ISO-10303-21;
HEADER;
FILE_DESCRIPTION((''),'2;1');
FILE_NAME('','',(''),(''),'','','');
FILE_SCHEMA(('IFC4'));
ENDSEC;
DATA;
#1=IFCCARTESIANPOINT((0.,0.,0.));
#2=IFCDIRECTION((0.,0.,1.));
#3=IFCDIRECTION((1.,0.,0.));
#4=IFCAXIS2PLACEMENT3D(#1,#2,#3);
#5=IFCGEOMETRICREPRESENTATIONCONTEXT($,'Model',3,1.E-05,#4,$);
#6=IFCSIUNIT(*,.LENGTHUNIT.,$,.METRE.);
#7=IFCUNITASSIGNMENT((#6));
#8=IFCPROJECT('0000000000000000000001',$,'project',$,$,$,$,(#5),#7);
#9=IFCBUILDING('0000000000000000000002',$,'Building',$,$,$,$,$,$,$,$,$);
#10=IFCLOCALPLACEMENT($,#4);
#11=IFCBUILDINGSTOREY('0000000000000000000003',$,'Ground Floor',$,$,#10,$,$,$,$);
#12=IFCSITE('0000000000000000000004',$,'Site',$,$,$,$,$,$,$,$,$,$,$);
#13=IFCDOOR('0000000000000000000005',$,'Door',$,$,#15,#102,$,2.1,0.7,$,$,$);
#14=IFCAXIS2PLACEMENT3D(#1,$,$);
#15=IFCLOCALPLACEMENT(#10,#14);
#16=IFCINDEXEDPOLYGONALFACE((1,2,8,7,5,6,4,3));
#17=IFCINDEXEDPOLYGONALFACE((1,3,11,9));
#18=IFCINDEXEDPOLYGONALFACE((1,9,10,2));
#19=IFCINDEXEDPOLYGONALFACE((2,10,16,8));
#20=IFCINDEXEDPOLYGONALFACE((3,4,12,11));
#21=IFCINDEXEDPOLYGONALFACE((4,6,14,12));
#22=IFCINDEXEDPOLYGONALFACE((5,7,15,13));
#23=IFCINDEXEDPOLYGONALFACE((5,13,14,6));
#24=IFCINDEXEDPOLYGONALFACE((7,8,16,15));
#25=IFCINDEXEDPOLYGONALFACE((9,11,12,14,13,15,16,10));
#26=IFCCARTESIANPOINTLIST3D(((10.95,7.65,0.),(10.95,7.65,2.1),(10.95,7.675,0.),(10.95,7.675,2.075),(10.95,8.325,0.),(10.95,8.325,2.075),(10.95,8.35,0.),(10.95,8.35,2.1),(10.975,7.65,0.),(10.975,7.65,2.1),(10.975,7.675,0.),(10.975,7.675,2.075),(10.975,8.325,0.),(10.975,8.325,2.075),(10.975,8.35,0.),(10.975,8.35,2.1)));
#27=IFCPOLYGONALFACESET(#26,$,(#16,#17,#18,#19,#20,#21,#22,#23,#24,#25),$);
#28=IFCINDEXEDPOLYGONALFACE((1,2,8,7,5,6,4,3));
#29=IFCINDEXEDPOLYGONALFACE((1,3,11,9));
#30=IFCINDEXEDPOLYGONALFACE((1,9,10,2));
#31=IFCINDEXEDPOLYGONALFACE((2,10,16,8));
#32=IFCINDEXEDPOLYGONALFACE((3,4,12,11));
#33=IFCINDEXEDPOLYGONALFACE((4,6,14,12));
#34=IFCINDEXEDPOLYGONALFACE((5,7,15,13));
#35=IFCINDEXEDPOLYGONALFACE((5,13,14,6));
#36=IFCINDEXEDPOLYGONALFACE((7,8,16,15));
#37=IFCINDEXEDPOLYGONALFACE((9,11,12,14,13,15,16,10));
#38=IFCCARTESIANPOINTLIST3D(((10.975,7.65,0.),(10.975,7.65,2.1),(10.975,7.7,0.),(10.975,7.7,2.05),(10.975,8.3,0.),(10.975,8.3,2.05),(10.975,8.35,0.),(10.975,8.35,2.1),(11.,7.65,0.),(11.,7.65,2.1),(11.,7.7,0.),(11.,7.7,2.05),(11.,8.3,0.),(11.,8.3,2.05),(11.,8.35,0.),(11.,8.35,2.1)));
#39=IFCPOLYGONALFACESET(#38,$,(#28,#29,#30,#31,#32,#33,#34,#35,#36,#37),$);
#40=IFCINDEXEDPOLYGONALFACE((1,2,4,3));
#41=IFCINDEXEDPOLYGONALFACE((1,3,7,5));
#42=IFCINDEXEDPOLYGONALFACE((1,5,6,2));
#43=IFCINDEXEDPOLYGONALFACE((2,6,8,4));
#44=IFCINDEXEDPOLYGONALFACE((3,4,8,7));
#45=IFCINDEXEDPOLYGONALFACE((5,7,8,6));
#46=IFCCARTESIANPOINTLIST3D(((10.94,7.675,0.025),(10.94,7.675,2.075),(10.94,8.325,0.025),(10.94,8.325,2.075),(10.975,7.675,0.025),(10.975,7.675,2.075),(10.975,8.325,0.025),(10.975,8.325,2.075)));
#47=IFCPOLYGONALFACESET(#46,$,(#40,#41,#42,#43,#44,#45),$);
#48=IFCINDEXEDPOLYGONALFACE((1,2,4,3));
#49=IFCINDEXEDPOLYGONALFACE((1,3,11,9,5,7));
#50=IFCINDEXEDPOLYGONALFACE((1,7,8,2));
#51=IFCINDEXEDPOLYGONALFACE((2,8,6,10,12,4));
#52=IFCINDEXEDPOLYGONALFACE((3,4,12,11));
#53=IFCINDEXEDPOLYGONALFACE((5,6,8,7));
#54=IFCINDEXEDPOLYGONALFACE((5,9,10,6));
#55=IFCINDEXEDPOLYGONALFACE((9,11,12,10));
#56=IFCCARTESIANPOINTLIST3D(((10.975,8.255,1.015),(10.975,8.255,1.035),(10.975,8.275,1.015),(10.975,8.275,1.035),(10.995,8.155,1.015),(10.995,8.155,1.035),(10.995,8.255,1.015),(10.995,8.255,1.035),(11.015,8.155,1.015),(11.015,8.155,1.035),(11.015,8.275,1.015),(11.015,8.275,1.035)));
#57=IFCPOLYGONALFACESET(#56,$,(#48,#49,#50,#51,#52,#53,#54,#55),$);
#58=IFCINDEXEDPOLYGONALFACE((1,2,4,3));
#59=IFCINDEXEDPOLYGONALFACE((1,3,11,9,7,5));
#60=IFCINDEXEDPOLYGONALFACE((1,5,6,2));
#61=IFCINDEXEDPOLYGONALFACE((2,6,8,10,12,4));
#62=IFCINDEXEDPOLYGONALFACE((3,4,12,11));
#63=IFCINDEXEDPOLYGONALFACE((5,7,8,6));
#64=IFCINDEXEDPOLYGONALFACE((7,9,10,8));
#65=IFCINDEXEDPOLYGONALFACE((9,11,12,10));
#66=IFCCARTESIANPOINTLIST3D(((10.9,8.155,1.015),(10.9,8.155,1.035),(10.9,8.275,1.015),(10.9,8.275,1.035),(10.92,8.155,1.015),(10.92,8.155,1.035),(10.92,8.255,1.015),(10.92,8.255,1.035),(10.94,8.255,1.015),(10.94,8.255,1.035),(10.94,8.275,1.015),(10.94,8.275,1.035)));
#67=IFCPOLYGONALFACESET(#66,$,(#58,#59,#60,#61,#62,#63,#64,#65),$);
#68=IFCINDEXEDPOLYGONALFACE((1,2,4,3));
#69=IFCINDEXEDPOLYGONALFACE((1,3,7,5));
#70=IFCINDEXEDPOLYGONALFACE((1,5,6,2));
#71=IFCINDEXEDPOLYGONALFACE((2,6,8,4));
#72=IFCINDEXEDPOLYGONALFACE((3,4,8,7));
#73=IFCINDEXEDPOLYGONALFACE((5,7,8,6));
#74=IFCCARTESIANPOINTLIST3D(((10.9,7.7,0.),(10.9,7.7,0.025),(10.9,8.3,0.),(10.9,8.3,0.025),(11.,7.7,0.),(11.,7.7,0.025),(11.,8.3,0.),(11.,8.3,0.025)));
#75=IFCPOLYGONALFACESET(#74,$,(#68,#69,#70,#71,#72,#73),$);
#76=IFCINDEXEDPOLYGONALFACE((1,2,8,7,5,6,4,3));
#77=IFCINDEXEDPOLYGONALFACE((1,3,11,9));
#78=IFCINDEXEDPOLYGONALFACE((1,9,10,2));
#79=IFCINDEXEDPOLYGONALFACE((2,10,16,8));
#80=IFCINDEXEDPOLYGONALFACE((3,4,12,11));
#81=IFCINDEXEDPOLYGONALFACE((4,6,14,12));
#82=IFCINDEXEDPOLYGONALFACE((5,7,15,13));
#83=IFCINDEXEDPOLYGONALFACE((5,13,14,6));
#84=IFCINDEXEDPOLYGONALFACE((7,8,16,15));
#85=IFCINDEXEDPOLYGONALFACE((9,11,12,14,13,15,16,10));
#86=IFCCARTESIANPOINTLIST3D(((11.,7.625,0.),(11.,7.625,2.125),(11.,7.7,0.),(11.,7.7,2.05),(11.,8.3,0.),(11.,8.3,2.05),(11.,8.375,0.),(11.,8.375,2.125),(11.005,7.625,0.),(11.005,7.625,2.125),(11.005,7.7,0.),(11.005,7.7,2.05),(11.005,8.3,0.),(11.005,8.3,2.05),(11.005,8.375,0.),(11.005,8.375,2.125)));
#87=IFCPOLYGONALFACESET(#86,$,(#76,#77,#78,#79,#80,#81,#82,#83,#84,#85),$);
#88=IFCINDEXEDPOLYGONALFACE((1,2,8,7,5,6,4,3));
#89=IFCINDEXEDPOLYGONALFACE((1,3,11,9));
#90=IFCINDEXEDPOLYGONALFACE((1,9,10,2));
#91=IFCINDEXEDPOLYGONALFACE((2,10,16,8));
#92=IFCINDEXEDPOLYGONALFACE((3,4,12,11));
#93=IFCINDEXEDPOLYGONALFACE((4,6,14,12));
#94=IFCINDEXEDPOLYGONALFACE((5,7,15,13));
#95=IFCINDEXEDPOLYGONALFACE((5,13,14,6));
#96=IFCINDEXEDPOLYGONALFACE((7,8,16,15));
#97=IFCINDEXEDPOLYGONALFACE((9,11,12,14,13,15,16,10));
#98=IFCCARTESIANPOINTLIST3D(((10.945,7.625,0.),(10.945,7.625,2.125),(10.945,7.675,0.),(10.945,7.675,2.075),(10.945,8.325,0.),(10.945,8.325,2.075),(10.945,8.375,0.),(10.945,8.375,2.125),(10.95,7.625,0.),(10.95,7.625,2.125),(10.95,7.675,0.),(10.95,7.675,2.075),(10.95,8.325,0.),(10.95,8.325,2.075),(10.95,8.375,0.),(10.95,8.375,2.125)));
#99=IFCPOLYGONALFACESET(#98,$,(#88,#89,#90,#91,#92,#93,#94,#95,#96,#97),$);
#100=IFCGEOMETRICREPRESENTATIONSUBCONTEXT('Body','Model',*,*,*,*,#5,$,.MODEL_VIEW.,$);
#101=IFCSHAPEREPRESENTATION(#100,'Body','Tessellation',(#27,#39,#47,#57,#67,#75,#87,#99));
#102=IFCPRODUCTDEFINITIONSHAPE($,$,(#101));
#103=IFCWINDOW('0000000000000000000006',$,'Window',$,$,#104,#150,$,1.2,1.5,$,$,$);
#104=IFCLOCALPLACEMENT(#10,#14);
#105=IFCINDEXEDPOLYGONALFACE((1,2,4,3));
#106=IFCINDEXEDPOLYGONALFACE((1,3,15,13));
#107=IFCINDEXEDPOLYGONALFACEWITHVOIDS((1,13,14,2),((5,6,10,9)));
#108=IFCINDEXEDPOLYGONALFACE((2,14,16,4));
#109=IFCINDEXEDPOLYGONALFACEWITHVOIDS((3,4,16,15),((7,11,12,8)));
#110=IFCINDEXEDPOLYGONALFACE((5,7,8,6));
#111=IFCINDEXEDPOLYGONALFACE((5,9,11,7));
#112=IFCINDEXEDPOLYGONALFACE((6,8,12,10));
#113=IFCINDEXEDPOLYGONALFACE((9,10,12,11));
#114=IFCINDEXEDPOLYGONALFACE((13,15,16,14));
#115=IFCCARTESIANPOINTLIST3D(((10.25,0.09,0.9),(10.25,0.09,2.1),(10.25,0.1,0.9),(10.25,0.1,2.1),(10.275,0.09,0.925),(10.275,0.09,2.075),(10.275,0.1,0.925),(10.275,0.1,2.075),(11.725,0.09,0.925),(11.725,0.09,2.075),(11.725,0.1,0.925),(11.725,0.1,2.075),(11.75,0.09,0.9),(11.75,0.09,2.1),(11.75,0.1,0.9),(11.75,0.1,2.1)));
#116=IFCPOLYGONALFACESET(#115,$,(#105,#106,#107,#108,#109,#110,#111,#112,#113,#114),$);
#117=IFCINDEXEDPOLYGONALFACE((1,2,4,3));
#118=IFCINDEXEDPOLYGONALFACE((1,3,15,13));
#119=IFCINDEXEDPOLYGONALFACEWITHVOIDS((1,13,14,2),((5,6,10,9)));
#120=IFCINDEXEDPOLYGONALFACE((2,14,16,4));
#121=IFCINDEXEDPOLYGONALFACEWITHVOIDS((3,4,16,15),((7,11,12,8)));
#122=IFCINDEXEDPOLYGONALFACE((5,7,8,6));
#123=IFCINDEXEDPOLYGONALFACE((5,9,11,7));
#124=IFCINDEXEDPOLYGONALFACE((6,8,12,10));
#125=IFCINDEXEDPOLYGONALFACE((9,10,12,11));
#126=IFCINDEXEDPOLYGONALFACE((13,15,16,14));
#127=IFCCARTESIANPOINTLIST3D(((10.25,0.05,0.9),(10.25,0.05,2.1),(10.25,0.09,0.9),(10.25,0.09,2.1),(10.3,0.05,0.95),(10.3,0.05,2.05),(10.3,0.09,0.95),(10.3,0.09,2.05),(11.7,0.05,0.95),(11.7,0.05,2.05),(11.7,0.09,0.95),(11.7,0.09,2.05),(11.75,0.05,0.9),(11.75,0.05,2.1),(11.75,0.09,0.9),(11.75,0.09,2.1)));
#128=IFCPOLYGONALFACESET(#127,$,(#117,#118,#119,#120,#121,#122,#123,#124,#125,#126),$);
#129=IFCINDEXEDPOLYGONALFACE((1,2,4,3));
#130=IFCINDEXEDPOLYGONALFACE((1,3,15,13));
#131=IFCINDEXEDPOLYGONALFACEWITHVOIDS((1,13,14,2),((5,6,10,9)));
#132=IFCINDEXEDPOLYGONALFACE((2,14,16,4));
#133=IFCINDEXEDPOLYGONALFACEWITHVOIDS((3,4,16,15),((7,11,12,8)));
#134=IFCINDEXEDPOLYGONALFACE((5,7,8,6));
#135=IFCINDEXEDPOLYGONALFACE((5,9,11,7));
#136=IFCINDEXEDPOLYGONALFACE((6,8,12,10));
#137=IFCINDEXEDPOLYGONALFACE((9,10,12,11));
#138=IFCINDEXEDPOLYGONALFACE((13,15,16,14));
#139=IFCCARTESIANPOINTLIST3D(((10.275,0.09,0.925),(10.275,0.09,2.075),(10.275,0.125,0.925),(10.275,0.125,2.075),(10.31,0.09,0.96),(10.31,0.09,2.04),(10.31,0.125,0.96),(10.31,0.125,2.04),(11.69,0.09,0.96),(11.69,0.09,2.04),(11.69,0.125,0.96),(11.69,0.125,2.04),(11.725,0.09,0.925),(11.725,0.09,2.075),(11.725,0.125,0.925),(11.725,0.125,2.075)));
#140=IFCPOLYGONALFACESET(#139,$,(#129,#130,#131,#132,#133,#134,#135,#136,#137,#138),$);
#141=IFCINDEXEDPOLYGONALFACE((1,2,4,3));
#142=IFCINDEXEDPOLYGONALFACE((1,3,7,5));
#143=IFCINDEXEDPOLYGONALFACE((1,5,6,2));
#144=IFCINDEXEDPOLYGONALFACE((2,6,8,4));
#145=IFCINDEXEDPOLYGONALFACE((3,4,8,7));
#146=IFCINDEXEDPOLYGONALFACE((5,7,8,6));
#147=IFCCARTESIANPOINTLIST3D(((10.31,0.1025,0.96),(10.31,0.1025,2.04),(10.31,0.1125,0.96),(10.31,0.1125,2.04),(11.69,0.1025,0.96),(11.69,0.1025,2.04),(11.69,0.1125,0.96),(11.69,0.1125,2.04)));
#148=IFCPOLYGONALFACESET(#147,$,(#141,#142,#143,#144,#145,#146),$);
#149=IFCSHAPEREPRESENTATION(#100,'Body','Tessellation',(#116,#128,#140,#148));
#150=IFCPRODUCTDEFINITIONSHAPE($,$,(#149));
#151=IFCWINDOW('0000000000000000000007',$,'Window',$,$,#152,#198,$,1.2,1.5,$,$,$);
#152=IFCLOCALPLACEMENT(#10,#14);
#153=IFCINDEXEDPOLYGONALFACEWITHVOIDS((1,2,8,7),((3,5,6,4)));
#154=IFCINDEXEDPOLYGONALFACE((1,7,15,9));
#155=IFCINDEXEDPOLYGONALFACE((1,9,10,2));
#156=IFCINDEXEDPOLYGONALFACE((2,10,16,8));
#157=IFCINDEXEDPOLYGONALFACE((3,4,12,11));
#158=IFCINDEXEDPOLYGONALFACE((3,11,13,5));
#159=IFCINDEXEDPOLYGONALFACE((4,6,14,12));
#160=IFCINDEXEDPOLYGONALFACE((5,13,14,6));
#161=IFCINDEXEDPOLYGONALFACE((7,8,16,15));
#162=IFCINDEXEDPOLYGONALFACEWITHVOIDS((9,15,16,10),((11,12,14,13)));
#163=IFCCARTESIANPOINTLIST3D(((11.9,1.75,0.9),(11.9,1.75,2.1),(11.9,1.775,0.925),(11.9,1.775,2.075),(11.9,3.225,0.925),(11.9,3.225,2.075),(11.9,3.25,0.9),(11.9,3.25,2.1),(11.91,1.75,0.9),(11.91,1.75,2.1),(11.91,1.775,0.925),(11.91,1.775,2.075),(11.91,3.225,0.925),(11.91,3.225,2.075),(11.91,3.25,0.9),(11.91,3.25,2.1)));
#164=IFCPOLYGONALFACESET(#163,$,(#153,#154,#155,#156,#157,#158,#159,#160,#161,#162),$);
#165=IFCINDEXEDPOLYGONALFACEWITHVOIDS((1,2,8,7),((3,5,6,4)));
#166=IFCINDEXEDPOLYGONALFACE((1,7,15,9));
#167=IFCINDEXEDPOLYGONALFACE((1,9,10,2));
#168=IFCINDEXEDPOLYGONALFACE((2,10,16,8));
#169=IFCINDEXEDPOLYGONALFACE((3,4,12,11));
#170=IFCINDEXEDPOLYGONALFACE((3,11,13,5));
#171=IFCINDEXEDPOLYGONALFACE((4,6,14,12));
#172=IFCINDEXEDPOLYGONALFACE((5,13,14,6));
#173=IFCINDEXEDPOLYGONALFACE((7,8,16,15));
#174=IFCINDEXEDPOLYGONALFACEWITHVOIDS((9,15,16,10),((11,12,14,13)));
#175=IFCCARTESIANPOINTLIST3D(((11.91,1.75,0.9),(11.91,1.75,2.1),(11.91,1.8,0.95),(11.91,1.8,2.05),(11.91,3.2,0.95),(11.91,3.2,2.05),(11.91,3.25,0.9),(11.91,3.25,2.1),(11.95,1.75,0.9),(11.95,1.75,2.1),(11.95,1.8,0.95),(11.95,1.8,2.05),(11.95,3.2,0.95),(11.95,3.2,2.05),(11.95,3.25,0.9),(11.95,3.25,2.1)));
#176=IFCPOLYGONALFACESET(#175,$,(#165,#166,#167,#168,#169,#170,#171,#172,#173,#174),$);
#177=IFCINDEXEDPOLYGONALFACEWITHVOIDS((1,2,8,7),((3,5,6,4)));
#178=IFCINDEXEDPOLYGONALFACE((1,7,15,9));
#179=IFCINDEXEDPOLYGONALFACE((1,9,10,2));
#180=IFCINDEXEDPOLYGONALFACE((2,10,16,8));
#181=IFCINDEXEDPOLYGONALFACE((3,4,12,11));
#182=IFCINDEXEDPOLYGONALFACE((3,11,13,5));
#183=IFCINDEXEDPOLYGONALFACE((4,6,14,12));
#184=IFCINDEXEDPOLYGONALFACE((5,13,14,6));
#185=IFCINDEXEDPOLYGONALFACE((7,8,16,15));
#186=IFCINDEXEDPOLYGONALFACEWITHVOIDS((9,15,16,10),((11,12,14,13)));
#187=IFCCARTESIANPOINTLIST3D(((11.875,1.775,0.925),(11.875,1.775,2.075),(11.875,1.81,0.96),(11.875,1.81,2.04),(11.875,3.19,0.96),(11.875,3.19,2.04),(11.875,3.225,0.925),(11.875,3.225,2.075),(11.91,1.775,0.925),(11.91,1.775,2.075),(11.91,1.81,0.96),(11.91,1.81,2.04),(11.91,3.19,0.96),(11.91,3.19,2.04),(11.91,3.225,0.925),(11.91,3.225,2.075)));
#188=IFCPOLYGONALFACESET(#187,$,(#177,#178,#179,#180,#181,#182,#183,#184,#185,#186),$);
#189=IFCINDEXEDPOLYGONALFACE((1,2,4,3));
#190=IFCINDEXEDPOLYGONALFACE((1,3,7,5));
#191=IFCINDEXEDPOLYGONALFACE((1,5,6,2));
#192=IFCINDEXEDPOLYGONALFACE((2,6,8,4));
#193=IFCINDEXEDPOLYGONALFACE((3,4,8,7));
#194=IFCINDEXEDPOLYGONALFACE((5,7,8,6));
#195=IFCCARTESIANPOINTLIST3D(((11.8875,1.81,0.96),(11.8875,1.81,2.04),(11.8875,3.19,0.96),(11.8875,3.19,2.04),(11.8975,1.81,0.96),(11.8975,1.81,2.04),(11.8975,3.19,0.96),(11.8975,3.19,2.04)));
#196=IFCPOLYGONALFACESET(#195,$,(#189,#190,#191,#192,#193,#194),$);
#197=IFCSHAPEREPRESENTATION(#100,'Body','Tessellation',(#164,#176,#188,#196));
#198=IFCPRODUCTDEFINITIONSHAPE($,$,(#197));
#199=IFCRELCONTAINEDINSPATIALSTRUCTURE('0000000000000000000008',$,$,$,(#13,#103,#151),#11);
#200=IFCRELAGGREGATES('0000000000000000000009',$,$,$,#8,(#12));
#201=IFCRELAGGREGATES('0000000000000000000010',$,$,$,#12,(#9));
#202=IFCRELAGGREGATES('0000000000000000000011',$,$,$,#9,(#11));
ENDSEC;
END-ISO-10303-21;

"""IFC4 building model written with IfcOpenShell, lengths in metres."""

from ifc_helpers import new_model, si_unit, frame, origin_with_axes, place, context, subcontext, project, spatial, line, indexed_curve, outline, extrude, element, save


model = new_model("IFC4")

# Units and contexts
model_context = context("Model", 3, precision=1e-05, world=origin_with_axes())
body_context = subcontext(model_context, "Body", "Model", "MODEL_VIEW")
ifc_project = project(units=[si_unit("LENGTHUNIT", "METRE")], contexts=[model_context])

# Site, building, storey
site = spatial("IfcSite", under=ifc_project, Name="Site")
building = spatial("IfcBuilding", under=site, Name="Building")
storey_placement = place(None, origin_with_axes())
storey = spatial("IfcBuildingStorey", under=building, at=storey_placement, Name="Ground Floor")

# Door
door_1_placement = place(storey_placement, frame((11.0, 7.65, 0.0), z_axis=(0.0, 0.0, 1.0), x_axis=(0.0, 1.0, 0.0)))
element("IfcDoor", 1, at=door_1_placement, inside=storey, Name="Door", OverallHeight=2.1, OverallWidth=0.7, context=body_context, shape_type="SweptSolid", body=[
    extrude(outline(indexed_curve([(0.0, 0.0), (0.0, 2.1), (0.7, 2.1), (0.7, 0.0), (0.675, 0.0), (0.675, 2.075), (0.025, 2.075), (0.025, 0.0)], segments=[line(1, 2, 3, 4, 5, 6, 7, 8, 1)])), frame((0.0, 0.025, 0.0), z_axis=(0.0, -1.0, 0.0), x_axis=(1.0, 0.0, 0.0)), (0.0, 0.0, -1.0), 0.025),
    extrude(outline(indexed_curve([(0.0, 0.0), (0.0, 2.1), (0.7, 2.1), (0.7, 0.0), (0.65, 0.0), (0.65, 2.05), (0.05, 2.05), (0.05, 0.0)], segments=[line(1, 2, 3, 4, 5, 6, 7, 8, 1)])), frame((0.0, 0.0, 0.0), z_axis=(0.0, -1.0, 0.0), x_axis=(1.0, 0.0, 0.0)), (0.0, 0.0, -1.0), 0.025),
    extrude(outline(indexed_curve([(0.0, 0.0), (0.65, 0.0), (0.65, 0.035), (0.0, 0.035)], segments=[line(1, 2, 3, 4, 1)])), frame((0.025, 0.025, 0.025), z_axis=(0.0, 0.0, 1.0), x_axis=(1.0, 0.0, 0.0)), (0.0, 0.0, 1.0), 2.05),
    extrude(outline(indexed_curve([(0.0, 0.0), (0.0, -0.04), (-0.12, -0.04), (-0.12, -0.02), (-0.02, -0.02), (-0.02, 0.0)], segments=[line(1, 2, 3, 4, 5, 6, 1)])), frame((0.625, 0.025, 1.015), z_axis=(0.0, 0.0, 1.0), x_axis=(1.0, 0.0, 0.0)), (0.0, 0.0, 1.0), 0.02),
    extrude(outline(indexed_curve([(0.0, 0.0), (0.0, 0.04), (-0.12, 0.04), (-0.12, 0.02), (-0.02, 0.02), (-0.02, 0.0)], segments=[line(1, 2, 3, 4, 5, 6, 1)])), frame((0.625, 0.06, 1.015), z_axis=(0.0, 0.0, 1.0), x_axis=(1.0, 0.0, 0.0)), (0.0, 0.0, 1.0), 0.02),
    extrude(outline(indexed_curve([(0.0, 0.0), (0.6, 0.0), (0.6, 0.1), (0.0, 0.1)], segments=[line(1, 2, 3, 4, 1)])), frame((0.05, 0.0, 0.0), z_axis=(0.0, 0.0, 1.0), x_axis=(1.0, 0.0, 0.0)), (0.0, 0.0, 1.0), 0.025),
    extrude(outline(indexed_curve([(0.0, 0.0), (0.0, 2.125), (0.75, 2.125), (0.75, 0.0), (0.675, 0.0), (0.675, 2.05), (0.075, 2.05), (0.075, 0.0)], segments=[line(1, 2, 3, 4, 5, 6, 7, 8, 1)])), frame((-0.025, -0.005, 0.0), z_axis=(0.0, -1.0, 0.0), x_axis=(1.0, 0.0, 0.0)), (0.0, 0.0, -1.0), 0.005),
    extrude(outline(indexed_curve([(0.0, 0.0), (0.0, 2.125), (0.75, 2.125), (0.75, 0.0), (0.7, 0.0), (0.7, 2.075), (0.05, 2.075), (0.05, 0.0)], segments=[line(1, 2, 3, 4, 5, 6, 7, 8, 1)])), frame((-0.025, 0.05, 0.0), z_axis=(0.0, -1.0, 0.0), x_axis=(1.0, 0.0, 0.0)), (0.0, 0.0, -1.0), 0.005),
])

# Windows
for number, where, z_axis, x_axis, name in (
    (2, (10.25, 0.0, 0.9), (0.0, 0.0, 1.0), (1.0, 0.0, 0.0), "Window"),
    (3, (12.0, 1.75, 0.9), (0.0, 0.0, 1.0), (0.0, 1.0, 0.0), "Window"),
):
    element("IfcWindow", number, at=place(storey_placement, frame(where, z_axis=z_axis, x_axis=x_axis)), inside=storey, Name=name, OverallHeight=1.2, OverallWidth=1.5, context=body_context, shape_type="SweptSolid", body=[
        extrude(outline(indexed_curve([(0.0, 0.0), (1.5, 0.0), (1.5, 1.2), (0.0, 1.2)], segments=[line(1, 2, 3, 4, 1)]), holes=[indexed_curve([(0.025, 0.025), (1.475, 0.025), (1.475, 1.175), (0.025, 1.175)], segments=[line(1, 2, 3, 4, 1)])]), frame((0.0, 0.09, 0.0), z_axis=(0.0, -1.0, 0.0), x_axis=(1.0, 0.0, 0.0)), (0.0, 0.0, -1.0), 0.01),
        extrude(outline(indexed_curve([(0.0, 0.0), (1.5, 0.0), (1.5, 1.2), (0.0, 1.2)], segments=[line(1, 2, 3, 4, 1)]), holes=[indexed_curve([(0.05, 0.05), (1.45, 0.05), (1.45, 1.15), (0.05, 1.15)], segments=[line(1, 2, 3, 4, 1)])]), frame((0.0, 0.05, 0.0), z_axis=(0.0, -1.0, 0.0), x_axis=(1.0, 0.0, 0.0)), (0.0, 0.0, -1.0), 0.04),
        extrude(outline(indexed_curve([(0.0, 0.0), (1.45, 0.0), (1.45, 1.15), (0.0, 1.15)], segments=[line(1, 2, 3, 4, 1)]), holes=[indexed_curve([(0.035, 0.035), (1.415, 0.035), (1.415, 1.115), (0.035, 1.115)], segments=[line(1, 2, 3, 4, 1)])]), frame((0.025, 0.09, 0.025), z_axis=(0.0, -1.0, 0.0), x_axis=(1.0, 0.0, 0.0)), (0.0, 0.0, -1.0), 0.035),
        extrude(outline(indexed_curve([(0.035, 0.035), (1.415, 0.035), (1.415, 1.115), (0.035, 1.115)], segments=[line(1, 2, 3, 4, 1)])), frame((0.025, 0.1025, 0.025), z_axis=(0.0, -1.0, 0.0), x_axis=(1.0, 0.0, 0.0)), (0.0, 0.0, -1.0), 0.01),
    ])

save(model, "model.ifc")
